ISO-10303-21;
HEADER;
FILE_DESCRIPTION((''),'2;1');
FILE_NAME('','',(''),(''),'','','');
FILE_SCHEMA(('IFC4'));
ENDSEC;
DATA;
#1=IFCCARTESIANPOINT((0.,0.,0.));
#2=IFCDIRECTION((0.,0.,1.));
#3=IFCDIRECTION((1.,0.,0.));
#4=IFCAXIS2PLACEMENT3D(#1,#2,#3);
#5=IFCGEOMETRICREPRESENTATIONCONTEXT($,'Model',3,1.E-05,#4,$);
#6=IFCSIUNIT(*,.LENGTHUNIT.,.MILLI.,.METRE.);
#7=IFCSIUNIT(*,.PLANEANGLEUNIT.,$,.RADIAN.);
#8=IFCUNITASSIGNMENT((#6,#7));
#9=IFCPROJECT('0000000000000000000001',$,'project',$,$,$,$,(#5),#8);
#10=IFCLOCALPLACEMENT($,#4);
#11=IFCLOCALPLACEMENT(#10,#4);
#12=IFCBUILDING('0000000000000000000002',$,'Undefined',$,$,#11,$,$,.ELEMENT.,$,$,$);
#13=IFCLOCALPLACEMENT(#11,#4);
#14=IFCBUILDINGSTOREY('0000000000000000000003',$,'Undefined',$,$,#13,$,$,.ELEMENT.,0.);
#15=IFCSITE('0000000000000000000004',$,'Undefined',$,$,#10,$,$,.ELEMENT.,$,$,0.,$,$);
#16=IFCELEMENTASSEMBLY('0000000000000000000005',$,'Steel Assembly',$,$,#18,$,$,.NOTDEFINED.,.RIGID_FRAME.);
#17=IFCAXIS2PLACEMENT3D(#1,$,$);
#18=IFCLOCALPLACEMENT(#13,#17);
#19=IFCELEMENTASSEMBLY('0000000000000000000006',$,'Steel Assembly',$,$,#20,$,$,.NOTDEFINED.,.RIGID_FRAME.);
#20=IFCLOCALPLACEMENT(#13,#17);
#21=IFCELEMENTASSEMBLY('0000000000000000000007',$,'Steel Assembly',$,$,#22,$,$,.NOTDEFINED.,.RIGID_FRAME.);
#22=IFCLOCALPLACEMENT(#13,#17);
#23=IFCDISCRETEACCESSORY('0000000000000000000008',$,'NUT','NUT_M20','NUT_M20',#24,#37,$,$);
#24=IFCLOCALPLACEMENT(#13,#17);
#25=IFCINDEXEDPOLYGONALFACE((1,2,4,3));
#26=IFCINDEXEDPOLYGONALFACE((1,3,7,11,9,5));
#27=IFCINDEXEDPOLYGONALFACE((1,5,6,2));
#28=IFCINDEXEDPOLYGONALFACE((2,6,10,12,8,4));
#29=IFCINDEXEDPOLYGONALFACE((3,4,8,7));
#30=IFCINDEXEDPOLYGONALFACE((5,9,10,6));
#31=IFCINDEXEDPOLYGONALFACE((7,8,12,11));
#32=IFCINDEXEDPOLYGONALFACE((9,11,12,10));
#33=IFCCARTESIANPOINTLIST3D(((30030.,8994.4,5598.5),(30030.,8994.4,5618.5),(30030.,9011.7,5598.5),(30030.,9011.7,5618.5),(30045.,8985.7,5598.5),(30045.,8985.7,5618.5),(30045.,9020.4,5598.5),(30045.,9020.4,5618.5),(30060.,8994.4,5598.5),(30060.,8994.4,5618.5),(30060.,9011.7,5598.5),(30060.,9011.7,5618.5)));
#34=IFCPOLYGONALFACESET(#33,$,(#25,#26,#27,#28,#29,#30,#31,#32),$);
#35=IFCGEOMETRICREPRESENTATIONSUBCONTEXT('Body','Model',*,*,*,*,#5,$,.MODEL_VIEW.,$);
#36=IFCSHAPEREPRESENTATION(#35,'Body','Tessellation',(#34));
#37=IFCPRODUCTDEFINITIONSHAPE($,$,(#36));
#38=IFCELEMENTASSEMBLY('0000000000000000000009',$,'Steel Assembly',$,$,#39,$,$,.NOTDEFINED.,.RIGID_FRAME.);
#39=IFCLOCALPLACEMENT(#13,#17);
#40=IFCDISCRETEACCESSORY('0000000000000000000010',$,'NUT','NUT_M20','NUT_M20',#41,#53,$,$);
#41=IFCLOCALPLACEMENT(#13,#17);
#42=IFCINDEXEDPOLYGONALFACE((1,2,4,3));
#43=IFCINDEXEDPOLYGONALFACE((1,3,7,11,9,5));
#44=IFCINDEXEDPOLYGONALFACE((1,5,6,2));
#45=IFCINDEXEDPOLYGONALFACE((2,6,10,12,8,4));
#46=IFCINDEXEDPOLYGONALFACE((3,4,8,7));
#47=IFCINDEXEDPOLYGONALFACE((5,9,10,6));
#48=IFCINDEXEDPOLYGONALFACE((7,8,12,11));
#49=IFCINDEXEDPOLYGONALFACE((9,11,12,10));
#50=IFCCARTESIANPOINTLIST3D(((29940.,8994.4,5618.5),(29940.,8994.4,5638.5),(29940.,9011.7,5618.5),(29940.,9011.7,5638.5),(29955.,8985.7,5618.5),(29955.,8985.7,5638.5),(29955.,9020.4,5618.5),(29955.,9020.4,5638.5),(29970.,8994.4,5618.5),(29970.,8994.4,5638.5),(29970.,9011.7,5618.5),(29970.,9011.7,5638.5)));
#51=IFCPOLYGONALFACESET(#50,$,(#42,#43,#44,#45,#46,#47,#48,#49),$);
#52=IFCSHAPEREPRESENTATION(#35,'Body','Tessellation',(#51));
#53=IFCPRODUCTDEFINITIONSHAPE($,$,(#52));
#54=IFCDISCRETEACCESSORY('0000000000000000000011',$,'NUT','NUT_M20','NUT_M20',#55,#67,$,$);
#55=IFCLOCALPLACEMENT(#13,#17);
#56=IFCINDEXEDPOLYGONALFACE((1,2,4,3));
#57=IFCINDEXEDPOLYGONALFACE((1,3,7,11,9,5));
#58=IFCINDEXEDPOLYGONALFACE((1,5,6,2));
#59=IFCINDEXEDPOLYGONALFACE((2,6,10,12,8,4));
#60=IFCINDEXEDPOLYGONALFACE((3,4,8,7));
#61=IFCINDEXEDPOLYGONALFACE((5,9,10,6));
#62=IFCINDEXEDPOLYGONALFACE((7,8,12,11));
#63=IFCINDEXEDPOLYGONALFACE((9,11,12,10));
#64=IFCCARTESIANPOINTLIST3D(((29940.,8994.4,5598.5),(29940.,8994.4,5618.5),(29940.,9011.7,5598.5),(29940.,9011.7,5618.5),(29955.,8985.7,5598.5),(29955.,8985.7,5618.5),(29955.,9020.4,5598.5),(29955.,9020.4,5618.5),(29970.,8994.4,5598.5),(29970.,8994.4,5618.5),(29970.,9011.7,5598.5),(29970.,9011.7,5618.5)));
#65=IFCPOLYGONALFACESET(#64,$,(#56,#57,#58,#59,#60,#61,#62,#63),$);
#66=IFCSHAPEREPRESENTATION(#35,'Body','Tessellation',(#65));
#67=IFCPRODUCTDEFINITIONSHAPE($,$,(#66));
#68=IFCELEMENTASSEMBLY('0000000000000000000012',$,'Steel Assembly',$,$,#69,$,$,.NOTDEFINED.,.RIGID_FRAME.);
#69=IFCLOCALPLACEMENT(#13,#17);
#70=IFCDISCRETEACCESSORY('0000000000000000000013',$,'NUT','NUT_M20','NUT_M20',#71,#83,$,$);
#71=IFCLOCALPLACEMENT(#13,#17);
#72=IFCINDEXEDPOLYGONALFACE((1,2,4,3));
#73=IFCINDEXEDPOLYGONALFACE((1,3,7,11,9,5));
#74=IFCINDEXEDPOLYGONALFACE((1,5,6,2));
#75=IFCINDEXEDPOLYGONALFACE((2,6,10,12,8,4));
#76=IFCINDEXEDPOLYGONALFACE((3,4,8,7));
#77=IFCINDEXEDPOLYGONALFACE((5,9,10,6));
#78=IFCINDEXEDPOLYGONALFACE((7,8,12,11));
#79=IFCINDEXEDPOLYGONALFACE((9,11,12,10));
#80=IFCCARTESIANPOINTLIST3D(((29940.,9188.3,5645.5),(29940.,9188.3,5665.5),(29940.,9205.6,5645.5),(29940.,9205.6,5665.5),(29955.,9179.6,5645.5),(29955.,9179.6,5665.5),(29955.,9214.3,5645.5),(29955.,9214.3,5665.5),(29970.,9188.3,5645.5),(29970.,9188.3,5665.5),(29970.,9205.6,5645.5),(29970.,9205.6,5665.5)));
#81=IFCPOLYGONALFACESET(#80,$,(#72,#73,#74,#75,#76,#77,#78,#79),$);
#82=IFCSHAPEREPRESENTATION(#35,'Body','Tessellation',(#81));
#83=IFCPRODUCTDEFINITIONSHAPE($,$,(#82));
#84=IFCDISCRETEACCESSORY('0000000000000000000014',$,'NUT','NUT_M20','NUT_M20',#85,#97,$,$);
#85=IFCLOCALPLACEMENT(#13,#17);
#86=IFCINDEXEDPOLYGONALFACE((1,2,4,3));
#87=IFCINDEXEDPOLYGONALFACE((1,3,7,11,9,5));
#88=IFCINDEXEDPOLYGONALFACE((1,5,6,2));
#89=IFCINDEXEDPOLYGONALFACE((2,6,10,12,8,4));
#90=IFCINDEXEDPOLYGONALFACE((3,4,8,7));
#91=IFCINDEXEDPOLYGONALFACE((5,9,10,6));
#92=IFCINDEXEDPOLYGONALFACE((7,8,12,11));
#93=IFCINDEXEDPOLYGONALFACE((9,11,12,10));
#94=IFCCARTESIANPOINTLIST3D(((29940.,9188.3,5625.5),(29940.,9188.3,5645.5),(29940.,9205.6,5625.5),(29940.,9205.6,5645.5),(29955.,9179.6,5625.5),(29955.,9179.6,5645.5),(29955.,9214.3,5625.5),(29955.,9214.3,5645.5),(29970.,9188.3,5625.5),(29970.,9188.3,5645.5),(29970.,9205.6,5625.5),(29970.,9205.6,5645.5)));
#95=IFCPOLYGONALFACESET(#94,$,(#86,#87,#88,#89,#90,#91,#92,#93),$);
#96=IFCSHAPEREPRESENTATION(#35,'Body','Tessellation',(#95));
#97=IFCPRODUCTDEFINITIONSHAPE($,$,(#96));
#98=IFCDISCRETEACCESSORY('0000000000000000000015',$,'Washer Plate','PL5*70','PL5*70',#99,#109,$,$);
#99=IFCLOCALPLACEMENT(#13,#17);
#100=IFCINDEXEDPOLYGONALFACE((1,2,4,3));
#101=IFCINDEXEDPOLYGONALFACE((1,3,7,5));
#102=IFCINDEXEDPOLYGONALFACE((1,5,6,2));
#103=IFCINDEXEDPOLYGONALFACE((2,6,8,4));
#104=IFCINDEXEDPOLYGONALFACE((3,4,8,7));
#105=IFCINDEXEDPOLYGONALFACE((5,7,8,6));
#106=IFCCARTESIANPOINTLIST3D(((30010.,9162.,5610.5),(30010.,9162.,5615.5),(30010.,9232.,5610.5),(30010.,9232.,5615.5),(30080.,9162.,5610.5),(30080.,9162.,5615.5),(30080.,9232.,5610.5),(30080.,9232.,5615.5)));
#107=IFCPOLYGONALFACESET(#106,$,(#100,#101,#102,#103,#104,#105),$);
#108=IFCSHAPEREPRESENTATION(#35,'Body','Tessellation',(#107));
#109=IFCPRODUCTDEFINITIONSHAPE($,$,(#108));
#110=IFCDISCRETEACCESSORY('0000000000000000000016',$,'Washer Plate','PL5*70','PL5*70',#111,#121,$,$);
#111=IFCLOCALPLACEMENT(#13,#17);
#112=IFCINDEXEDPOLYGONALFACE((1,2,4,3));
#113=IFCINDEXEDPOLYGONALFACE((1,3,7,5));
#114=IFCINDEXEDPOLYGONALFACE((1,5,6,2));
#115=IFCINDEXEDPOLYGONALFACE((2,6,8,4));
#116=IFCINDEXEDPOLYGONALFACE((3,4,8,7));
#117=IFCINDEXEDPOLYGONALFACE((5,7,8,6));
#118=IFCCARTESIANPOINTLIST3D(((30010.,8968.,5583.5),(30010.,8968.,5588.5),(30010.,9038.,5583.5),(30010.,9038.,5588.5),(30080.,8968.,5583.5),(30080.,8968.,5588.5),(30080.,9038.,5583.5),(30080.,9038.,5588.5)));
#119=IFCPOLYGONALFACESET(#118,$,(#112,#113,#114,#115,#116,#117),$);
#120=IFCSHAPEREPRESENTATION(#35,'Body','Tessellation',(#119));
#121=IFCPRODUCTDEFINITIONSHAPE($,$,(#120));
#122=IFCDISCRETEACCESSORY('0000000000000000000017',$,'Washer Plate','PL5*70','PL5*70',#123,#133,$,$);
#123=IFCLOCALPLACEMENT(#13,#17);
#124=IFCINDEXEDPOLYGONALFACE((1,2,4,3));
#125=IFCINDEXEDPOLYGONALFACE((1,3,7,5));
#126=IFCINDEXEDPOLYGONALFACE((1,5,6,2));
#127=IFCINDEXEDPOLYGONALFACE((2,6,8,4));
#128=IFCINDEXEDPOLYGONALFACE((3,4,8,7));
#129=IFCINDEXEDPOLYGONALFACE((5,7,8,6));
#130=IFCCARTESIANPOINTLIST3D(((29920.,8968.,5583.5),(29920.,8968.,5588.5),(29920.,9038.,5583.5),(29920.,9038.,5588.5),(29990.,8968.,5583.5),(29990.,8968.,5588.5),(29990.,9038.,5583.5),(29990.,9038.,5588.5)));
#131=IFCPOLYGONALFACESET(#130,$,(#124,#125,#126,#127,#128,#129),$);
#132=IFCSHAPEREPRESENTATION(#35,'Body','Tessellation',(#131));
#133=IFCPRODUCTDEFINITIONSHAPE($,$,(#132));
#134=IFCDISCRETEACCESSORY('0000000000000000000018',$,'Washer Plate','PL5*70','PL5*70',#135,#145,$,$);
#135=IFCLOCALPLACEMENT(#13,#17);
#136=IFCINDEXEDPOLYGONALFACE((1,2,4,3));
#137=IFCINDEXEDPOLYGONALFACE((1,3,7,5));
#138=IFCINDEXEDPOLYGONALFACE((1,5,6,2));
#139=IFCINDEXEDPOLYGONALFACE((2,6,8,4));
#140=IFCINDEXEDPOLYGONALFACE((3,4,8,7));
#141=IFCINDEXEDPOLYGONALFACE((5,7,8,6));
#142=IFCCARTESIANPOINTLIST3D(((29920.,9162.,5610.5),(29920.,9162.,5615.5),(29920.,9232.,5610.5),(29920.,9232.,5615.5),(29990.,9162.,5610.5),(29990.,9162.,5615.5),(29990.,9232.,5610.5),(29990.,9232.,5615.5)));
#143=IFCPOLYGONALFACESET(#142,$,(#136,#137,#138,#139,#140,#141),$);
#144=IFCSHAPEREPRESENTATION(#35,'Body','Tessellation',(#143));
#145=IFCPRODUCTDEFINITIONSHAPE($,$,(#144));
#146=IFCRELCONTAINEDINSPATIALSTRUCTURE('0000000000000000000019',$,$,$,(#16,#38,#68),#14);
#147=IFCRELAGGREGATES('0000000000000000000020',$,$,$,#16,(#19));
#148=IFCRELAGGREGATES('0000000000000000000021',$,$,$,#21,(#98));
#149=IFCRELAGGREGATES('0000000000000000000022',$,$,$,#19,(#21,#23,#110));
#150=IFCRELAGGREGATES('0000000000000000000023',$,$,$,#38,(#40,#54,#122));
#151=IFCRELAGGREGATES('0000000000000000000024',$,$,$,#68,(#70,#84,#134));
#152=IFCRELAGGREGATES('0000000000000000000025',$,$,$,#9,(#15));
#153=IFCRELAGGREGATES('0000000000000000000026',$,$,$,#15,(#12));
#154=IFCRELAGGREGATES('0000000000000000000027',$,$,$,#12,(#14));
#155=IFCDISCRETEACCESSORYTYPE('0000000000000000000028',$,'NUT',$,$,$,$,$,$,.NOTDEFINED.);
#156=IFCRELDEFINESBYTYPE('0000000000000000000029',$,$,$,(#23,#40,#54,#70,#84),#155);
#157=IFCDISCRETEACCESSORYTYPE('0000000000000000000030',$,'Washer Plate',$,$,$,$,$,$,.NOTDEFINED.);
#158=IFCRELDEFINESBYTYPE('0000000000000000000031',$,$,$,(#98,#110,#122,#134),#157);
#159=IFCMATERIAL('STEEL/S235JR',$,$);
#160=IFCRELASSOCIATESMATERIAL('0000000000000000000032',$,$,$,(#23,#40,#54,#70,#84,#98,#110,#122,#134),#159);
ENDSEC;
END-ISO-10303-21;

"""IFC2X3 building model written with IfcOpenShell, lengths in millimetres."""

from ifc_helpers import new_model, si_unit, frame, origin_with_axes, place, context, subcontext, project, spatial, polyline, outline, extrude, material, type_object, element, aggregate, save


model = new_model("IFC2X3")

# Units and contexts
model_context = context("Model", 3, precision=1e-05, world=origin_with_axes())
body_context = subcontext(model_context, "Body", "Model", "MODEL_VIEW")
ifc_project = project(units=[si_unit("LENGTHUNIT", "METRE", prefix="MILLI"), si_unit("PLANEANGLEUNIT", "RADIAN")], contexts=[model_context])

# Site, building, storey
site_placement = place(None, origin_with_axes())
site = spatial("IfcSite", under=ifc_project, at=site_placement, Name="Undefined", CompositionType="ELEMENT", RefElevation=0.0)
building_placement = place(site_placement, origin_with_axes())
building = spatial("IfcBuilding", under=site, at=building_placement, Name="Undefined", CompositionType="ELEMENT")
storey_placement = place(building_placement, origin_with_axes())
storey = spatial("IfcBuildingStorey", under=building, at=storey_placement, Name="Undefined", CompositionType="ELEMENT", Elevation=0.0)

# Shared definitions
ifc_material_1 = material(Name="STEEL/S235JR")

# Element assemblies, discrete accessory
assembly_1_placement = place(storey_placement, origin_with_axes())
assembly_1 = element("IfcElementAssembly", 1, at=assembly_1_placement, inside=storey, Name="Steel Assembly", AssemblyPlace="NOTDEFINED", PredefinedType="RIGID_FRAME")
assembly_2_placement = place(assembly_1_placement, origin_with_axes())
assembly_2 = element("IfcElementAssembly", 2, at=assembly_2_placement, Name="Steel Assembly", AssemblyPlace="NOTDEFINED", PredefinedType="RIGID_FRAME")
aggregate(assembly_1, [assembly_2])
assembly_3_placement = place(assembly_2_placement, origin_with_axes())
assembly_3 = element("IfcElementAssembly", 3, at=assembly_3_placement, Name="Steel Assembly", AssemblyPlace="NOTDEFINED", PredefinedType="RIGID_FRAME")
discrete_accessory_type_1 = type_object("IfcDiscreteAccessoryType", Name="NUT")
discrete_accessory_1_placement = place(assembly_2_placement, frame((30045.0, 9003.0, 5618.5), z_axis=(-1.0, 0.0, 0.0), x_axis=(0.0, 0.0, -1.0)))
discrete_accessory_1 = element("IfcDiscreteAccessory", 4, at=discrete_accessory_1_placement, type_object=discrete_accessory_type_1, material=ifc_material_1, Name="NUT", Description="NUT_M20", ObjectType="NUT_M20", context=body_context, shape_type="SweptSolid", body=[
    extrude(outline(polyline([(8.7, 15.0), (17.3, 0.0), (8.7, -15.0), (-8.7, -15.0), (-17.3, 0.0), (-8.7, 15.0), (8.7, 15.0)])), frame((20.0, 0.0, 0.0), z_axis=(-1.0, 0.0, 0.0), x_axis=(0.0, -1.0, 0.0)), (0.0, 0.0, 1.0), 20.0),
])

# Element assemblies, discrete accessories
assembly_4_placement = place(storey_placement, origin_with_axes())
assembly_4 = element("IfcElementAssembly", 5, at=assembly_4_placement, inside=storey, Name="Steel Assembly", AssemblyPlace="NOTDEFINED", PredefinedType="RIGID_FRAME")
discrete_accessory_2_placement = place(assembly_4_placement, frame((29955.0, 9003.0, 5638.5), z_axis=(-1.0, 0.0, 0.0), x_axis=(0.0, 0.0, -1.0)))
discrete_accessory_2 = element("IfcDiscreteAccessory", 6, at=discrete_accessory_2_placement, type_object=discrete_accessory_type_1, material=ifc_material_1, Name="NUT", Description="NUT_M20", ObjectType="NUT_M20", context=body_context, shape_type="SweptSolid", body=[
    extrude(outline(polyline([(8.7, 15.0), (17.3, 0.0), (8.7, -15.0), (-8.7, -15.0), (-17.3, 0.0), (-8.7, 15.0), (8.7, 15.0)])), frame((20.0, 0.0, 0.0), z_axis=(-1.0, 0.0, 0.0), x_axis=(0.0, -1.0, 0.0)), (0.0, 0.0, 1.0), 20.0),
])
discrete_accessory_3_placement = place(assembly_4_placement, frame((29955.0, 9003.0, 5618.5), z_axis=(-1.0, 0.0, 0.0), x_axis=(0.0, 0.0, -1.0)))
discrete_accessory_3 = element("IfcDiscreteAccessory", 7, at=discrete_accessory_3_placement, type_object=discrete_accessory_type_1, material=ifc_material_1, Name="NUT", Description="NUT_M20", ObjectType="NUT_M20", context=body_context, shape_type="SweptSolid", body=[
    extrude(outline(polyline([(8.7, 15.0), (17.3, 0.0), (8.7, -15.0), (-8.7, -15.0), (-17.3, 0.0), (-8.7, 15.0), (8.7, 15.0)])), frame((20.0, 0.0, 0.0), z_axis=(-1.0, 0.0, 0.0), x_axis=(0.0, -1.0, 0.0)), (0.0, 0.0, 1.0), 20.0),
])
assembly_5_placement = place(storey_placement, origin_with_axes())
assembly_5 = element("IfcElementAssembly", 8, at=assembly_5_placement, inside=storey, Name="Steel Assembly", AssemblyPlace="NOTDEFINED", PredefinedType="RIGID_FRAME")
discrete_accessory_4_placement = place(assembly_5_placement, frame((29955.0, 9197.0, 5665.5), z_axis=(-1.0, 0.0, 0.0), x_axis=(0.0, 0.0, -1.0)))
discrete_accessory_4 = element("IfcDiscreteAccessory", 9, at=discrete_accessory_4_placement, type_object=discrete_accessory_type_1, material=ifc_material_1, Name="NUT", Description="NUT_M20", ObjectType="NUT_M20", context=body_context, shape_type="SweptSolid", body=[
    extrude(outline(polyline([(8.7, 15.0), (17.3, 0.0), (8.7, -15.0), (-8.7, -15.0), (-17.3, 0.0), (-8.7, 15.0), (8.7, 15.0)])), frame((20.0, 0.0, 0.0), z_axis=(-1.0, 0.0, 0.0), x_axis=(0.0, -1.0, 0.0)), (0.0, 0.0, 1.0), 20.0),
])
discrete_accessory_5_placement = place(assembly_5_placement, frame((29955.0, 9197.0, 5645.5), z_axis=(-1.0, 0.0, 0.0), x_axis=(0.0, 0.0, -1.0)))
discrete_accessory_5 = element("IfcDiscreteAccessory", 10, at=discrete_accessory_5_placement, type_object=discrete_accessory_type_1, material=ifc_material_1, Name="NUT", Description="NUT_M20", ObjectType="NUT_M20", context=body_context, shape_type="SweptSolid", body=[
    extrude(outline(polyline([(8.7, 15.0), (17.3, 0.0), (8.7, -15.0), (-8.7, -15.0), (-17.3, 0.0), (-8.7, 15.0), (8.7, 15.0)])), frame((20.0, 0.0, 0.0), z_axis=(-1.0, 0.0, 0.0), x_axis=(0.0, -1.0, 0.0)), (0.0, 0.0, 1.0), 20.0),
])

# Discrete accessories
discrete_accessory_type_2 = type_object("IfcDiscreteAccessoryType", Name="Washer Plate")
discrete_accessory_6_placement = place(assembly_3_placement, frame((30080.0, 9232.0, 5613.0), z_axis=(0.0, 0.0, -1.0), x_axis=(0.0, -1.0, 0.0)))
discrete_accessory_6 = element("IfcDiscreteAccessory", 11, at=discrete_accessory_6_placement, type_object=discrete_accessory_type_2, material=ifc_material_1, Name="Washer Plate", Description="PL5*70", ObjectType="PL5*70", context=body_context, shape_type="SweptSolid", body=[
    extrude(outline(polyline([(0.0, 0.0), (70.0, 0.0), (70.0, 70.0), (0.0, 70.0), (0.0, 0.0)])), frame((0.0, 0.0, -2.5), z_axis=(0.0, 0.0, 1.0), x_axis=(1.0, 0.0, 0.0)), (0.0, 0.0, 1.0), 5.0),
])
discrete_accessory_7_placement = place(assembly_2_placement, frame((30080.0, 8968.0, 5586.0), z_axis=(0.0, 0.0, 1.0), x_axis=(0.0, 1.0, 0.0)))
discrete_accessory_7 = element("IfcDiscreteAccessory", 12, at=discrete_accessory_7_placement, type_object=discrete_accessory_type_2, material=ifc_material_1, Name="Washer Plate", Description="PL5*70", ObjectType="PL5*70", context=body_context, shape_type="SweptSolid", body=[
    extrude(outline(polyline([(0.0, 0.0), (70.0, 0.0), (70.0, 70.0), (0.0, 70.0), (0.0, 0.0)])), frame((0.0, 0.0, -2.5), z_axis=(0.0, 0.0, 1.0), x_axis=(1.0, 0.0, 0.0)), (0.0, 0.0, 1.0), 5.0),
])
discrete_accessory_8_placement = place(assembly_4_placement, frame((29990.0, 8968.0, 5586.0), z_axis=(0.0, 0.0, 1.0), x_axis=(0.0, 1.0, 0.0)))
discrete_accessory_8 = element("IfcDiscreteAccessory", 13, at=discrete_accessory_8_placement, type_object=discrete_accessory_type_2, material=ifc_material_1, Name="Washer Plate", Description="PL5*70", ObjectType="PL5*70", context=body_context, shape_type="SweptSolid", body=[
    extrude(outline(polyline([(0.0, 0.0), (70.0, 0.0), (70.0, 70.0), (0.0, 70.0), (0.0, 0.0)])), frame((0.0, 0.0, -2.5), z_axis=(0.0, 0.0, 1.0), x_axis=(1.0, 0.0, 0.0)), (0.0, 0.0, 1.0), 5.0),
])
discrete_accessory_9_placement = place(assembly_5_placement, frame((29990.0, 9232.0, 5613.0), z_axis=(0.0, 0.0, -1.0), x_axis=(0.0, -1.0, 0.0)))
discrete_accessory_9 = element("IfcDiscreteAccessory", 14, at=discrete_accessory_9_placement, type_object=discrete_accessory_type_2, material=ifc_material_1, Name="Washer Plate", Description="PL5*70", ObjectType="PL5*70", context=body_context, shape_type="SweptSolid", body=[
    extrude(outline(polyline([(0.0, 0.0), (70.0, 0.0), (70.0, 70.0), (0.0, 70.0), (0.0, 0.0)])), frame((0.0, 0.0, -2.5), z_axis=(0.0, 0.0, 1.0), x_axis=(1.0, 0.0, 0.0)), (0.0, 0.0, 1.0), 5.0),
])
aggregate(assembly_3, [discrete_accessory_6])
aggregate(assembly_2, [assembly_3, discrete_accessory_1, discrete_accessory_7])
aggregate(assembly_4, [discrete_accessory_2, discrete_accessory_3, discrete_accessory_8])
aggregate(assembly_5, [discrete_accessory_4, discrete_accessory_5, discrete_accessory_9])

save(model, "model.ifc")
